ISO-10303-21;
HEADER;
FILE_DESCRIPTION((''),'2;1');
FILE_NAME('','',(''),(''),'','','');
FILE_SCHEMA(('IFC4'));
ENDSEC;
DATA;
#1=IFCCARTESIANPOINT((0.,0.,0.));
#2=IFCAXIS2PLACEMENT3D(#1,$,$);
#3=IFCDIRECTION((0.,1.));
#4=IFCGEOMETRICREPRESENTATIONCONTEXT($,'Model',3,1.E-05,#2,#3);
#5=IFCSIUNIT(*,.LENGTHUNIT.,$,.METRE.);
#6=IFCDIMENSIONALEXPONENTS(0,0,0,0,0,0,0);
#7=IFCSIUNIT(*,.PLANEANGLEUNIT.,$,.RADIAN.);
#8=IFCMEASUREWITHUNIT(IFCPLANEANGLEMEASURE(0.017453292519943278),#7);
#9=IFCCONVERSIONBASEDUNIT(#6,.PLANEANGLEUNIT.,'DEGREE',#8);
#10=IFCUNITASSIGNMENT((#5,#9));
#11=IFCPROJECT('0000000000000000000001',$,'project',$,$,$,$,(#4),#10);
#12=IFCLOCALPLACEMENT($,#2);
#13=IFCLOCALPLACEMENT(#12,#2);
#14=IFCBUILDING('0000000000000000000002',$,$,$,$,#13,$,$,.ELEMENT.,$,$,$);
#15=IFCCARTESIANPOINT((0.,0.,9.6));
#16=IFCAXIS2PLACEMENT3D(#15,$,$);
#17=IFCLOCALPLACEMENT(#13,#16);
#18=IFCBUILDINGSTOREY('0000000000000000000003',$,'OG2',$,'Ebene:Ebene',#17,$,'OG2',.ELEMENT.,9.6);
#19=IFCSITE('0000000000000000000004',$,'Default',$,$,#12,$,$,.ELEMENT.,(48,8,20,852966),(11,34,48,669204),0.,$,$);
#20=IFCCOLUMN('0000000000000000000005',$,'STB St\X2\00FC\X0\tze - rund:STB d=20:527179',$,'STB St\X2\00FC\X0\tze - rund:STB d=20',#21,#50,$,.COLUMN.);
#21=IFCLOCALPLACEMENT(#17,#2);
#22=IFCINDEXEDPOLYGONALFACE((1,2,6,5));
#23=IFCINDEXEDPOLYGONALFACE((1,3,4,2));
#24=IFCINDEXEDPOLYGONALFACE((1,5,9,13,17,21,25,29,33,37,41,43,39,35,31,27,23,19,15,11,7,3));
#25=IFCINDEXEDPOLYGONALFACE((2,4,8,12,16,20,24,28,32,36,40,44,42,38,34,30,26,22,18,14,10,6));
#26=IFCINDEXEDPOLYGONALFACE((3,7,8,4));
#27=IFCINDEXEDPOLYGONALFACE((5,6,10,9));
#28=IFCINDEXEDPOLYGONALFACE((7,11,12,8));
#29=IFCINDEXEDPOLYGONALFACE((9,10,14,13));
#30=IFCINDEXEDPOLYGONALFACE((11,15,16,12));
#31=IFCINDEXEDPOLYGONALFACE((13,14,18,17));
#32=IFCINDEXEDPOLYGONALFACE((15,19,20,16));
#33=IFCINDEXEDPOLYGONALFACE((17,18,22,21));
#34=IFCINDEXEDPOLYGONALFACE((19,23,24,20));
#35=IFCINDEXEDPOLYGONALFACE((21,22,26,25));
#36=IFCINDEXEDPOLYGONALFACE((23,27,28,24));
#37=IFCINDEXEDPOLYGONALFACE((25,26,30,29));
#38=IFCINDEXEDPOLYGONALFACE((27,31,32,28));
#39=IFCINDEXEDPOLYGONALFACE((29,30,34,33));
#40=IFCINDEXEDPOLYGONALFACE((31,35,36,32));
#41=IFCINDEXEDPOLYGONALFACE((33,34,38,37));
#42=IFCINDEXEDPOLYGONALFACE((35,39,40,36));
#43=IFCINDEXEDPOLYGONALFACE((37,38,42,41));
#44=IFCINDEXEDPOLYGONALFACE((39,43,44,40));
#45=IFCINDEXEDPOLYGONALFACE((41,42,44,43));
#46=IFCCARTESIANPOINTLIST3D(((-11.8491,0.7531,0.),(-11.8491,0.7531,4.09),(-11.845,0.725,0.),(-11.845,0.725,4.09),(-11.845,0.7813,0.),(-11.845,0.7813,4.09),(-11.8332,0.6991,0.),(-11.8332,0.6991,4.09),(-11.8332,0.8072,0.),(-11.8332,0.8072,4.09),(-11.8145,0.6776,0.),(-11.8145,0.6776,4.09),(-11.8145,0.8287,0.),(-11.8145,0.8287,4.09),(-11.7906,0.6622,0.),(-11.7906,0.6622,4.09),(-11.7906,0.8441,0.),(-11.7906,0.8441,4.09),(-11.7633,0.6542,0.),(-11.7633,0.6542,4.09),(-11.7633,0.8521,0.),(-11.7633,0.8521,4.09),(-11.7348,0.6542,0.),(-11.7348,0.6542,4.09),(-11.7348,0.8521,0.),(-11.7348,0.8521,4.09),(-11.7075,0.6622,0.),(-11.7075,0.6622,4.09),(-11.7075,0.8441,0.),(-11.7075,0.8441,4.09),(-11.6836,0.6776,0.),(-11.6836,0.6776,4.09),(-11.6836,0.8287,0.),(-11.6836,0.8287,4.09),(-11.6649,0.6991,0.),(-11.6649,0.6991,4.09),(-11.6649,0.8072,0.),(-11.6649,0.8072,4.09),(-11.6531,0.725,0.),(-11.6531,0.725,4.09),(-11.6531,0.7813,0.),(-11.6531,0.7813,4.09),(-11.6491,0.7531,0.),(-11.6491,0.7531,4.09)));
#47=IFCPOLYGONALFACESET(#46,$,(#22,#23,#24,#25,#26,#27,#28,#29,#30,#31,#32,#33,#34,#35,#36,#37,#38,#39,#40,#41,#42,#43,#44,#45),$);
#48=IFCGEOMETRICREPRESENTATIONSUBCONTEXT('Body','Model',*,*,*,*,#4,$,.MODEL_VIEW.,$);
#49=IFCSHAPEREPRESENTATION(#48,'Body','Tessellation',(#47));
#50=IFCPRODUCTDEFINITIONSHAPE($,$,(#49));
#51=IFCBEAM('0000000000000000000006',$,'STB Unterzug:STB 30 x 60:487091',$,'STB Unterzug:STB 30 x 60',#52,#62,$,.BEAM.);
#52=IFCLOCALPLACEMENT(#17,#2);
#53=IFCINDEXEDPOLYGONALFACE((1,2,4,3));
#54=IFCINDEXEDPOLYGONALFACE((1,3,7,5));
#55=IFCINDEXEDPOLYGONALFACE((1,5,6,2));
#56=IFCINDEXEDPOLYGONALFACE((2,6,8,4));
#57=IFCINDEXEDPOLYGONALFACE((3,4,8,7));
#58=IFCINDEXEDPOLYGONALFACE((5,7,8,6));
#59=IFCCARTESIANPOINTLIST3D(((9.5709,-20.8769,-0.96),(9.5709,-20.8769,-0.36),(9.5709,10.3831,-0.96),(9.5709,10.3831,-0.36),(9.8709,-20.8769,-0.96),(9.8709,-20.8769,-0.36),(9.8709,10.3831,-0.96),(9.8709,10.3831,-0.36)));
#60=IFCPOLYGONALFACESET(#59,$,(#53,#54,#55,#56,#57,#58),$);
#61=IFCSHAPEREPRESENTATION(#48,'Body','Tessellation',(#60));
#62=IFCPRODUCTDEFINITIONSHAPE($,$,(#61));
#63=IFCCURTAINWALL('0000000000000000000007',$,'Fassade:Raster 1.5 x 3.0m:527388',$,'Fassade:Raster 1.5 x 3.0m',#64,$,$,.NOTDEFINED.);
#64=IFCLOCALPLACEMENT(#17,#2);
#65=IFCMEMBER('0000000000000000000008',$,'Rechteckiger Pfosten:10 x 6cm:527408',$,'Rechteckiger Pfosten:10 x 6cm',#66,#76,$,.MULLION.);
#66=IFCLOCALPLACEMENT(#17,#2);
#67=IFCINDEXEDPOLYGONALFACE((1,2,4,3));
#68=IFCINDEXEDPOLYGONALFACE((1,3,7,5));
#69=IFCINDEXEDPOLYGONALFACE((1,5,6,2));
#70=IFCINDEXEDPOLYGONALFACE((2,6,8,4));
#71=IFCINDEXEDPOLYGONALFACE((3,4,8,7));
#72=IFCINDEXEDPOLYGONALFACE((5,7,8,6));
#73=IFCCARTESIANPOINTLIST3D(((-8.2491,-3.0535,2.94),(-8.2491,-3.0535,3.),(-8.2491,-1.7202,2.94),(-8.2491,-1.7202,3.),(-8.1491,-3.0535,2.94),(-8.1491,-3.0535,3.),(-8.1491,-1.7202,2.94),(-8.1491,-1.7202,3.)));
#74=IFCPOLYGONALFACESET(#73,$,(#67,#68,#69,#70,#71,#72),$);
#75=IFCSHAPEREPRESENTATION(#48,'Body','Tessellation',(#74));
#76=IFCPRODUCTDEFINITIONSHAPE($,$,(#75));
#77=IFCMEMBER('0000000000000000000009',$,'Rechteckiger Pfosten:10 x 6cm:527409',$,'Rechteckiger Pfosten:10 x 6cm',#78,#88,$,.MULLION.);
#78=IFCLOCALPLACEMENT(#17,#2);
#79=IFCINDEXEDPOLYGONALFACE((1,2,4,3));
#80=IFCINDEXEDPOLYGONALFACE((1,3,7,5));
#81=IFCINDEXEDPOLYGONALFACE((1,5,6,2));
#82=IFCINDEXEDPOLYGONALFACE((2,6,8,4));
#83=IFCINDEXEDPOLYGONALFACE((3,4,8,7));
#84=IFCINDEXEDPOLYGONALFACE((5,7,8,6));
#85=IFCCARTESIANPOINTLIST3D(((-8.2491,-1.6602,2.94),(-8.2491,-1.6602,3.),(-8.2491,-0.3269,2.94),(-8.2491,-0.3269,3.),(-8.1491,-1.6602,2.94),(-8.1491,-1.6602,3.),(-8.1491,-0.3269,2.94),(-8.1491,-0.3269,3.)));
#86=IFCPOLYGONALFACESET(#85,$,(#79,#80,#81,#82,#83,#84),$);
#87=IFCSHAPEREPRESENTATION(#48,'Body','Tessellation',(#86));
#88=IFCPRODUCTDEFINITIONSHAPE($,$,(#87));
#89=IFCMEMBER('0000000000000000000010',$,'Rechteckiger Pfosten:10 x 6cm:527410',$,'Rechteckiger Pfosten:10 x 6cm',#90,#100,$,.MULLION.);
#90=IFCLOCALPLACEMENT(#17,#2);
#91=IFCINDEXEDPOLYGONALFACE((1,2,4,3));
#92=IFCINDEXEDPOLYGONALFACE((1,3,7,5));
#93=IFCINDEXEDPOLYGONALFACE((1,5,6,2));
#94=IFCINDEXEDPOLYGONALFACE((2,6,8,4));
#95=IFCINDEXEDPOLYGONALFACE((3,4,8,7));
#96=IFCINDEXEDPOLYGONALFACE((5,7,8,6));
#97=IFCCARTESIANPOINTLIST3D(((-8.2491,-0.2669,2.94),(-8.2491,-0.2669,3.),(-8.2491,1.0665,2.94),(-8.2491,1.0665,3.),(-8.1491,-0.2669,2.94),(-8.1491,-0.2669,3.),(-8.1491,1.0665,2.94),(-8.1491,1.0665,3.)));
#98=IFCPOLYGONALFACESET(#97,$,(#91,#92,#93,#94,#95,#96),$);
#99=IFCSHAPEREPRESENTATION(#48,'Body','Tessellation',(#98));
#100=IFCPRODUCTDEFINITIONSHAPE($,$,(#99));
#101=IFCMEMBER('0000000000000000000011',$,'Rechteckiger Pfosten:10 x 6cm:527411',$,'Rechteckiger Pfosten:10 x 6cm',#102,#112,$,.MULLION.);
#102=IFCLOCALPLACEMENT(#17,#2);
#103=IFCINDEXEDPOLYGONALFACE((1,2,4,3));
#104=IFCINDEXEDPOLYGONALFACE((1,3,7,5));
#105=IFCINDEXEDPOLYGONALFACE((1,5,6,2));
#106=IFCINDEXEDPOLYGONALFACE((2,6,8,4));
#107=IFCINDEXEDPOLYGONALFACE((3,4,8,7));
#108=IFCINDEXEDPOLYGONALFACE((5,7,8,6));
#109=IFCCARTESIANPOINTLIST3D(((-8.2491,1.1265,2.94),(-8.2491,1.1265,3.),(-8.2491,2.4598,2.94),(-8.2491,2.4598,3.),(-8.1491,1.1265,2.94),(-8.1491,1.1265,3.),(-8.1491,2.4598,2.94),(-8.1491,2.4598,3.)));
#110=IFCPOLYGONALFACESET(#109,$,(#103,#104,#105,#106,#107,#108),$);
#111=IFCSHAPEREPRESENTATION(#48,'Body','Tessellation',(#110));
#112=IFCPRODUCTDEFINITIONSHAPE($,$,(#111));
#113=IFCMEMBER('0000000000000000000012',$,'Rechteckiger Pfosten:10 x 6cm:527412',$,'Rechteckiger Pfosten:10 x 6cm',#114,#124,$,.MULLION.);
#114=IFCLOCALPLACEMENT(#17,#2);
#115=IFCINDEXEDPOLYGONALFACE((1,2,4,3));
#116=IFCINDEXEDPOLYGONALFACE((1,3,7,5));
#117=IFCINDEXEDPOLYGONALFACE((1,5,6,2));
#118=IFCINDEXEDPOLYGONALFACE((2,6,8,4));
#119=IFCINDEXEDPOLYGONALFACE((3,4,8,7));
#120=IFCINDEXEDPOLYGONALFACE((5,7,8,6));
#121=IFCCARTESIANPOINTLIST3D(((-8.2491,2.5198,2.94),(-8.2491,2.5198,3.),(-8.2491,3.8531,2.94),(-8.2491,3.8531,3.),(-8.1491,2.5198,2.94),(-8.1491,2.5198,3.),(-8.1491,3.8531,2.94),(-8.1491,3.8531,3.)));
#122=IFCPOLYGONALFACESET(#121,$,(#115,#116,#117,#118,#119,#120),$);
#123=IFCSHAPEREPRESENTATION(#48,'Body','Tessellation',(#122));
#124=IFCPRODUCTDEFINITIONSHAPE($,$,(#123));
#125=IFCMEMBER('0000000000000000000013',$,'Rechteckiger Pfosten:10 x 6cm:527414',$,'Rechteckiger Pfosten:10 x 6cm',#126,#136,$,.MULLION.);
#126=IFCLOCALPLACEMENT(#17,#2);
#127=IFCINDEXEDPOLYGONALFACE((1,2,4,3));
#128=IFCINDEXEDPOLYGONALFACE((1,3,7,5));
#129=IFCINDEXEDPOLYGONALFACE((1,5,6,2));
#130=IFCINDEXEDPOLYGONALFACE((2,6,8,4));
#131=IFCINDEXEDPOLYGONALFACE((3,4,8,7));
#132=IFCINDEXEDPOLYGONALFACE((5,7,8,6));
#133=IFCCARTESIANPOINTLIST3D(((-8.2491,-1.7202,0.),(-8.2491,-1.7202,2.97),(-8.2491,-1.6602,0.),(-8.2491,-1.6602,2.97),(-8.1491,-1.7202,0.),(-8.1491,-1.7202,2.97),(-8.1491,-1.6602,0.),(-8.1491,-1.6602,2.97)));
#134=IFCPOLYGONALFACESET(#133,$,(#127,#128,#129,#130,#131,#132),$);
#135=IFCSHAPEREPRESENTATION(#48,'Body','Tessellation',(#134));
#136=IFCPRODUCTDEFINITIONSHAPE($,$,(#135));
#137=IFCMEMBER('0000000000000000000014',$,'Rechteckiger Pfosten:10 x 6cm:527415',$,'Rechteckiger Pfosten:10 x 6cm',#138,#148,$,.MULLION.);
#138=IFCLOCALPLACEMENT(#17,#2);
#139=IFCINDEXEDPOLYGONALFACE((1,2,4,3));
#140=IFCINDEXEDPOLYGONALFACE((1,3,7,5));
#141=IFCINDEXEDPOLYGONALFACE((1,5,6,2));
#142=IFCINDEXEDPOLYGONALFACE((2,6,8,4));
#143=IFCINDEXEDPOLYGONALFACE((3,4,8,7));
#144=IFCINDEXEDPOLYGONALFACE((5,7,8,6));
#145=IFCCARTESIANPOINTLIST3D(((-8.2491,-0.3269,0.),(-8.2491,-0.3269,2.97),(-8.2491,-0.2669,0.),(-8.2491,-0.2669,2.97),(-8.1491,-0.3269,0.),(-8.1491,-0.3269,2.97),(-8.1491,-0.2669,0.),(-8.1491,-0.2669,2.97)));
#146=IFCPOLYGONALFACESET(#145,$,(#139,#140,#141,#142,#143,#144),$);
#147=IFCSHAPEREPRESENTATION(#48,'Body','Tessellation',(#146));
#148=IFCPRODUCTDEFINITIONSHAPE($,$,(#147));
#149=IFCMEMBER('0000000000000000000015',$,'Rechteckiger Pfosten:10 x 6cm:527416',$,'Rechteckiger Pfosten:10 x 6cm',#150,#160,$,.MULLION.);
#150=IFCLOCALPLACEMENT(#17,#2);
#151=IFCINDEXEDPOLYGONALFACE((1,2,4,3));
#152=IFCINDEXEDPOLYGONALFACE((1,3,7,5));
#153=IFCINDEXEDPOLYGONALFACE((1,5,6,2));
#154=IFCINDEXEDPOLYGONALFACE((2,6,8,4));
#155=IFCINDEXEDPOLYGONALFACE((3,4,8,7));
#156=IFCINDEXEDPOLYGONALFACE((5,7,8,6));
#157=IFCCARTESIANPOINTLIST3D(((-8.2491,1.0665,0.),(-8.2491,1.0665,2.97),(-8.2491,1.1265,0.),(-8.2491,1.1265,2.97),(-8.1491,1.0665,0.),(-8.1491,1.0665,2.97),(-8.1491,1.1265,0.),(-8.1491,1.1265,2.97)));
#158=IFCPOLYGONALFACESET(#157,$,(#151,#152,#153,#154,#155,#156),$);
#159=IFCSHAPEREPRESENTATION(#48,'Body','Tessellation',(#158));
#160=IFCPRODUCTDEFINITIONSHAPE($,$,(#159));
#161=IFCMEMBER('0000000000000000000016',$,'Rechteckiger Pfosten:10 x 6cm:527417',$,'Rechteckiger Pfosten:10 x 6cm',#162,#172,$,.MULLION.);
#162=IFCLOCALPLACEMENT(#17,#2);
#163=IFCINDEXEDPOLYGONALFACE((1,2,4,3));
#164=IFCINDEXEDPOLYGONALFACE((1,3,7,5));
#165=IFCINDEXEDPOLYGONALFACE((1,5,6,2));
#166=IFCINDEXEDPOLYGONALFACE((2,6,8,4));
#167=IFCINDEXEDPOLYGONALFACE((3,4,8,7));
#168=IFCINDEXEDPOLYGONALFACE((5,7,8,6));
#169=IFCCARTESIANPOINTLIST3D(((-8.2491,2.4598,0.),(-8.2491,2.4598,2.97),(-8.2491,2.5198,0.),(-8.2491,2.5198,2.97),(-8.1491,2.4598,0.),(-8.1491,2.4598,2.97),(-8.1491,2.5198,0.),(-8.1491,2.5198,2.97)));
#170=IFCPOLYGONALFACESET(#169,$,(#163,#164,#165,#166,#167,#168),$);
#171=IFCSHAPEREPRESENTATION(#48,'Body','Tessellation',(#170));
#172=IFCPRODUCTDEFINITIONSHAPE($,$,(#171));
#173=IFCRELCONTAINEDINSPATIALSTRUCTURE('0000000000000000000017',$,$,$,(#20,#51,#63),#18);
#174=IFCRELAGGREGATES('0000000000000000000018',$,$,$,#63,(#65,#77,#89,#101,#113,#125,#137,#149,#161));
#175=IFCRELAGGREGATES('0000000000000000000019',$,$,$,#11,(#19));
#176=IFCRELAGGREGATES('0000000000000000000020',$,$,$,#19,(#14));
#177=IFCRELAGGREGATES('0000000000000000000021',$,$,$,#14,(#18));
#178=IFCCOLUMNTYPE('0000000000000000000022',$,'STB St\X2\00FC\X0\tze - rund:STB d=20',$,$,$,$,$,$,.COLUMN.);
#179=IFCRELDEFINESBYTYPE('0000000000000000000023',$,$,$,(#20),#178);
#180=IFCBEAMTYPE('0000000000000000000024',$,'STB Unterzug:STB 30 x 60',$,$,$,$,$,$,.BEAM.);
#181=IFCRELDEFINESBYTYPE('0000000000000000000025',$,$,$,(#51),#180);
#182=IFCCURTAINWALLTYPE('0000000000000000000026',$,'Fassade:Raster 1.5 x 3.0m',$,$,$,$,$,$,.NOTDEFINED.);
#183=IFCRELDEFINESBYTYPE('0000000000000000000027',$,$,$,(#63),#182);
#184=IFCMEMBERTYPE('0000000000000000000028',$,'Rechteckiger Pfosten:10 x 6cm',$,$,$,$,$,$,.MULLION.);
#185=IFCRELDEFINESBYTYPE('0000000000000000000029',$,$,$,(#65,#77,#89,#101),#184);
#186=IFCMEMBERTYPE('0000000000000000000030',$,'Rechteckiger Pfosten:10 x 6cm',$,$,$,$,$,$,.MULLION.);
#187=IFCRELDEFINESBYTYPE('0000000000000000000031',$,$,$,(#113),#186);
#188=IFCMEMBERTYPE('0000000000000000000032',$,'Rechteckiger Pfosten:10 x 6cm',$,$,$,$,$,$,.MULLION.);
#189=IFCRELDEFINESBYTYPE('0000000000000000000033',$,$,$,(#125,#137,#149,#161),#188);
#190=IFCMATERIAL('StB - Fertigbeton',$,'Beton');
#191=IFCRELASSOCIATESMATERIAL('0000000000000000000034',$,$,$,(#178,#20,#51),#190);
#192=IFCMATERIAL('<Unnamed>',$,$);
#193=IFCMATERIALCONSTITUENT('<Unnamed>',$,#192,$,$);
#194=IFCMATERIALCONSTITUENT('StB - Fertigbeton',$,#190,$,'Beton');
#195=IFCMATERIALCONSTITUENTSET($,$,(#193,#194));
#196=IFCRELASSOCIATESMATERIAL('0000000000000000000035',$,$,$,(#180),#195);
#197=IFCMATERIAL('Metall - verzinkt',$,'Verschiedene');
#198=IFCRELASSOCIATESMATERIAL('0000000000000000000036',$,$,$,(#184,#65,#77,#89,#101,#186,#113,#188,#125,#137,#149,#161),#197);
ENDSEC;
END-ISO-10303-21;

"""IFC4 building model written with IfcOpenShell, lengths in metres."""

from ifc_helpers import new_model, entity, si_unit, converted_unit, direction, frame, origin, place, context, subcontext, project, spatial, arc, indexed_curve, outline, extrude, source, transform, mapped, material, constituent, constituent_set, type_object, type_shapes, element, aggregate, save


model = new_model("IFC4")

# Units and contexts
model_context = context("Model", 3, precision=1e-05, world=origin(), true_north=direction((0.0, 1.0)))
body_context = subcontext(model_context, "Body", "Model", "MODEL_VIEW")
ifc_project = project(units=[si_unit("LENGTHUNIT", "METRE"), converted_unit("PLANEANGLEUNIT", "DEGREE", entity("IfcPlaneAngleMeasure", 0.017453292519943278), si_unit("PLANEANGLEUNIT", "RADIAN"), dimensions=[0, 0, 0, 0, 0, 0, 0])], contexts=[model_context])

# Site, building, storey
site_placement = place(None, origin())
site = spatial("IfcSite", under=ifc_project, at=site_placement, Name="Default", CompositionType="ELEMENT", RefLatitude=(48, 8, 20, 852966), RefLongitude=(11, 34, 48, 669204), RefElevation=0.0)
building_placement = place(site_placement, origin())
building = spatial("IfcBuilding", under=site, at=building_placement, CompositionType="ELEMENT")
storey_placement = place(building_placement, frame((0.0, 0.0, 9.6)))
storey = spatial("IfcBuildingStorey", under=building, at=storey_placement, Name="OG2", ObjectType="Ebene:Ebene", LongName="OG2", CompositionType="ELEMENT", Elevation=9.6)

# Column
ifc_material_1 = material(Name="StB - Fertigbeton", Category="Beton")
column_type = type_object("IfcColumnType", Name="STB Stütze - rund:STB d=20", PredefinedType="COLUMN", material=ifc_material_1)
shared_shape_1 = source(origin(), body_context, "Body", "SweptSolid", [
    extrude(outline(indexed_curve([(-0.1, 0.0), (0.0, -0.1), (0.1, 0.0), (0.0, 0.1)], segments=[arc(1, 2, 3), arc(3, 4, 1)], self_intersect=False)), frame((0.0, 0.0, 9.6)), (0.0, 0.0, 1.0), 4.09),
])
type_shapes(column_type, [shared_shape_1])
column_placement = place(storey_placement, frame((-11.7491, 0.7531, -9.6), z_axis=(0.0, 0.0, 1.0), x_axis=(-1.0, 0.0, 0.0)))
element("IfcColumn", 1, at=column_placement, inside=storey, type_object=column_type, material=ifc_material_1, Name="STB Stütze - rund:STB d=20:527179", ObjectType="STB Stütze - rund:STB d=20", PredefinedType="COLUMN", context=body_context, shape_type="MappedRepresentation", body=[
    mapped(shared_shape_1, transform((0.0, 0.0, 0.0), scale=1.0)),
])

# Beam
ifc_material_2 = material(Name="<Unnamed>")
ifc_constituent_1 = constituent(ifc_material_2, Name="<Unnamed>")
ifc_constituent_2 = constituent(ifc_material_1, Name="StB - Fertigbeton", Category="Beton")
ifc_constituent_set_1 = constituent_set(constituents=[ifc_constituent_1, ifc_constituent_2])
beam_type = type_object("IfcBeamType", Name="STB Unterzug:STB 30 x 60", PredefinedType="BEAM", material=ifc_constituent_set_1)
shared_shape_2 = source(origin(), body_context, "Body", "SweptSolid", [
    extrude(outline(indexed_curve([(-0.15, -0.3), (0.15, -0.3), (0.15, 0.3), (-0.15, 0.3), (-0.15, -0.3)], self_intersect=False)), frame((9.7209, 10.3831, 8.94), z_axis=(0.0, -1.0, 0.0), x_axis=(-1.0, 0.0, 0.0)), (0.0, 0.0, 1.0), 31.26),
])
type_shapes(beam_type, [shared_shape_2])
beam_placement = place(storey_placement, frame((0.0, 0.0, -9.6)))
element("IfcBeam", 2, at=beam_placement, inside=storey, type_object=beam_type, material=ifc_material_1, Name="STB Unterzug:STB 30 x 60:487091", ObjectType="STB Unterzug:STB 30 x 60", PredefinedType="BEAM", context=body_context, shape_type="MappedRepresentation", body=[
    mapped(shared_shape_2, transform((0.0, 0.0, 0.0), scale=1.0)),
])

# Curtain wall, members
curtain_wall_type = type_object("IfcCurtainWallType", Name="Fassade:Raster 1.5 x 3.0m", PredefinedType="NOTDEFINED")
curtain_wall_placement = place(storey_placement, frame((0.0, 0.0, -9.6)))
curtain_wall = element("IfcCurtainWall", 3, at=curtain_wall_placement, inside=storey, type_object=curtain_wall_type, Name="Fassade:Raster 1.5 x 3.0m:527388", ObjectType="Fassade:Raster 1.5 x 3.0m", PredefinedType="NOTDEFINED")
ifc_material_3 = material(Name="Metall - verzinkt", Category="Verschiedene")
member_type_1 = type_object("IfcMemberType", Name="Rechteckiger Pfosten:10 x 6cm", PredefinedType="MULLION", material=ifc_material_3)
shared_shape_3 = source(origin(), body_context, "Body", "SweptSolid", [
    extrude(outline(indexed_curve([(-0.03, -0.05), (0.03, -0.05), (0.03, 0.05), (-0.03, 0.05), (-0.03, -0.05)], self_intersect=False)), frame((0.0, 0.0, -1.3333), z_axis=(0.0, 0.0, 1.0), x_axis=(-1.0, 0.0, 0.0)), (0.0, 0.0, 1.0), 1.3333),
])
type_shapes(member_type_1, [shared_shape_3])
member_1_placement = place(curtain_wall_placement, frame((-8.1991, -1.7202, 12.57), z_axis=(0.0, 1.0, 0.0), x_axis=(0.0, 0.0, 1.0)))
member_1 = element("IfcMember", 4, at=member_1_placement, type_object=member_type_1, material=ifc_material_3, Name="Rechteckiger Pfosten:10 x 6cm:527408", ObjectType="Rechteckiger Pfosten:10 x 6cm", PredefinedType="MULLION", context=body_context, shape_type="MappedRepresentation", body=[
    mapped(shared_shape_3, transform((0.0, 0.0, 0.0), scale=1.0)),
])
member_2_placement = place(curtain_wall_placement, frame((-8.1991, -0.3269, 12.57), z_axis=(0.0, 1.0, 0.0), x_axis=(0.0, 0.0, 1.0)))
member_2 = element("IfcMember", 5, at=member_2_placement, type_object=member_type_1, material=ifc_material_3, Name="Rechteckiger Pfosten:10 x 6cm:527409", ObjectType="Rechteckiger Pfosten:10 x 6cm", PredefinedType="MULLION", context=body_context, shape_type="MappedRepresentation", body=[
    mapped(shared_shape_3, transform((0.0, 0.0, 0.0), scale=1.0)),
])
member_3_placement = place(curtain_wall_placement, frame((-8.1991, 1.0665, 12.57), z_axis=(0.0, 1.0, 0.0), x_axis=(0.0, 0.0, 1.0)))
member_3 = element("IfcMember", 6, at=member_3_placement, type_object=member_type_1, material=ifc_material_3, Name="Rechteckiger Pfosten:10 x 6cm:527410", ObjectType="Rechteckiger Pfosten:10 x 6cm", PredefinedType="MULLION", context=body_context, shape_type="MappedRepresentation", body=[
    mapped(shared_shape_3, transform((0.0, 0.0, 0.0), scale=1.0)),
])
member_4_placement = place(curtain_wall_placement, frame((-8.1991, 2.4598, 12.57), z_axis=(0.0, 1.0, 0.0), x_axis=(0.0, 0.0, 1.0)))
member_4 = element("IfcMember", 7, at=member_4_placement, type_object=member_type_1, material=ifc_material_3, Name="Rechteckiger Pfosten:10 x 6cm:527411", ObjectType="Rechteckiger Pfosten:10 x 6cm", PredefinedType="MULLION", context=body_context, shape_type="MappedRepresentation", body=[
    mapped(shared_shape_3, transform((0.0, 0.0, 0.0), scale=1.0)),
])
member_type_2 = type_object("IfcMemberType", Name="Rechteckiger Pfosten:10 x 6cm", PredefinedType="MULLION", material=ifc_material_3)
shared_shape_4 = source(origin(), body_context, "Body", "SweptSolid", [
    extrude(outline(indexed_curve([(-0.03, -0.05), (0.03, -0.05), (0.03, 0.05), (-0.03, 0.05), (-0.03, -0.05)], self_intersect=False)), frame((0.0, 0.0, -1.3333), z_axis=(0.0, 0.0, 1.0), x_axis=(-1.0, 0.0, 0.0)), (0.0, 0.0, 1.0), 1.3333),
])
type_shapes(member_type_2, [shared_shape_4])
member_5_placement = place(curtain_wall_placement, frame((-8.1991, 3.8531, 12.57), z_axis=(0.0, 1.0, 0.0), x_axis=(0.0, 0.0, 1.0)))
member_5 = element("IfcMember", 8, at=member_5_placement, type_object=member_type_2, material=ifc_material_3, Name="Rechteckiger Pfosten:10 x 6cm:527412", ObjectType="Rechteckiger Pfosten:10 x 6cm", PredefinedType="MULLION", context=body_context, shape_type="MappedRepresentation", body=[
    mapped(shared_shape_4, transform((0.0, 0.0, 0.0), scale=1.0)),
])
member_type_3 = type_object("IfcMemberType", Name="Rechteckiger Pfosten:10 x 6cm", PredefinedType="MULLION", material=ifc_material_3)
shared_shape_5 = source(origin(), body_context, "Body", "SweptSolid", [
    extrude(outline(indexed_curve([(-0.03, -0.05), (0.03, -0.05), (0.03, 0.05), (-0.03, 0.05), (-0.03, -0.05)], self_intersect=False)), frame((0.0, 0.0, -2.97), z_axis=(0.0, 0.0, 1.0), x_axis=(-1.0, 0.0, 0.0)), (0.0, 0.0, 1.0), 2.97),
])
type_shapes(member_type_3, [shared_shape_5])
member_6_placement = place(curtain_wall_placement, frame((-8.1991, -1.6902, 9.6), z_axis=(0.0, 0.0, -1.0), x_axis=(0.0, 1.0, 0.0)))
member_6 = element("IfcMember", 9, at=member_6_placement, type_object=member_type_3, material=ifc_material_3, Name="Rechteckiger Pfosten:10 x 6cm:527414", ObjectType="Rechteckiger Pfosten:10 x 6cm", PredefinedType="MULLION", context=body_context, shape_type="MappedRepresentation", body=[
    mapped(shared_shape_5, transform((0.0, 0.0, 0.0), scale=1.0)),
])
member_7_placement = place(curtain_wall_placement, frame((-8.1991, -0.2969, 9.6), z_axis=(0.0, 0.0, -1.0), x_axis=(0.0, 1.0, 0.0)))
member_7 = element("IfcMember", 10, at=member_7_placement, type_object=member_type_3, material=ifc_material_3, Name="Rechteckiger Pfosten:10 x 6cm:527415", ObjectType="Rechteckiger Pfosten:10 x 6cm", PredefinedType="MULLION", context=body_context, shape_type="MappedRepresentation", body=[
    mapped(shared_shape_5, transform((0.0, 0.0, 0.0), scale=1.0)),
])
member_8_placement = place(curtain_wall_placement, frame((-8.1991, 1.0965, 9.6), z_axis=(0.0, 0.0, -1.0), x_axis=(0.0, 1.0, 0.0)))
member_8 = element("IfcMember", 11, at=member_8_placement, type_object=member_type_3, material=ifc_material_3, Name="Rechteckiger Pfosten:10 x 6cm:527416", ObjectType="Rechteckiger Pfosten:10 x 6cm", PredefinedType="MULLION", context=body_context, shape_type="MappedRepresentation", body=[
    mapped(shared_shape_5, transform((0.0, 0.0, 0.0), scale=1.0)),
])
member_9_placement = place(curtain_wall_placement, frame((-8.1991, 2.4898, 9.6), z_axis=(0.0, 0.0, -1.0), x_axis=(0.0, 1.0, 0.0)))
member_9 = element("IfcMember", 12, at=member_9_placement, type_object=member_type_3, material=ifc_material_3, Name="Rechteckiger Pfosten:10 x 6cm:527417", ObjectType="Rechteckiger Pfosten:10 x 6cm", PredefinedType="MULLION", context=body_context, shape_type="MappedRepresentation", body=[
    mapped(shared_shape_5, transform((0.0, 0.0, 0.0), scale=1.0)),
])

aggregate(curtain_wall, [member_1, member_2, member_3, member_4, member_5, member_6, member_7, member_8, member_9])

save(model, "model.ifc")
